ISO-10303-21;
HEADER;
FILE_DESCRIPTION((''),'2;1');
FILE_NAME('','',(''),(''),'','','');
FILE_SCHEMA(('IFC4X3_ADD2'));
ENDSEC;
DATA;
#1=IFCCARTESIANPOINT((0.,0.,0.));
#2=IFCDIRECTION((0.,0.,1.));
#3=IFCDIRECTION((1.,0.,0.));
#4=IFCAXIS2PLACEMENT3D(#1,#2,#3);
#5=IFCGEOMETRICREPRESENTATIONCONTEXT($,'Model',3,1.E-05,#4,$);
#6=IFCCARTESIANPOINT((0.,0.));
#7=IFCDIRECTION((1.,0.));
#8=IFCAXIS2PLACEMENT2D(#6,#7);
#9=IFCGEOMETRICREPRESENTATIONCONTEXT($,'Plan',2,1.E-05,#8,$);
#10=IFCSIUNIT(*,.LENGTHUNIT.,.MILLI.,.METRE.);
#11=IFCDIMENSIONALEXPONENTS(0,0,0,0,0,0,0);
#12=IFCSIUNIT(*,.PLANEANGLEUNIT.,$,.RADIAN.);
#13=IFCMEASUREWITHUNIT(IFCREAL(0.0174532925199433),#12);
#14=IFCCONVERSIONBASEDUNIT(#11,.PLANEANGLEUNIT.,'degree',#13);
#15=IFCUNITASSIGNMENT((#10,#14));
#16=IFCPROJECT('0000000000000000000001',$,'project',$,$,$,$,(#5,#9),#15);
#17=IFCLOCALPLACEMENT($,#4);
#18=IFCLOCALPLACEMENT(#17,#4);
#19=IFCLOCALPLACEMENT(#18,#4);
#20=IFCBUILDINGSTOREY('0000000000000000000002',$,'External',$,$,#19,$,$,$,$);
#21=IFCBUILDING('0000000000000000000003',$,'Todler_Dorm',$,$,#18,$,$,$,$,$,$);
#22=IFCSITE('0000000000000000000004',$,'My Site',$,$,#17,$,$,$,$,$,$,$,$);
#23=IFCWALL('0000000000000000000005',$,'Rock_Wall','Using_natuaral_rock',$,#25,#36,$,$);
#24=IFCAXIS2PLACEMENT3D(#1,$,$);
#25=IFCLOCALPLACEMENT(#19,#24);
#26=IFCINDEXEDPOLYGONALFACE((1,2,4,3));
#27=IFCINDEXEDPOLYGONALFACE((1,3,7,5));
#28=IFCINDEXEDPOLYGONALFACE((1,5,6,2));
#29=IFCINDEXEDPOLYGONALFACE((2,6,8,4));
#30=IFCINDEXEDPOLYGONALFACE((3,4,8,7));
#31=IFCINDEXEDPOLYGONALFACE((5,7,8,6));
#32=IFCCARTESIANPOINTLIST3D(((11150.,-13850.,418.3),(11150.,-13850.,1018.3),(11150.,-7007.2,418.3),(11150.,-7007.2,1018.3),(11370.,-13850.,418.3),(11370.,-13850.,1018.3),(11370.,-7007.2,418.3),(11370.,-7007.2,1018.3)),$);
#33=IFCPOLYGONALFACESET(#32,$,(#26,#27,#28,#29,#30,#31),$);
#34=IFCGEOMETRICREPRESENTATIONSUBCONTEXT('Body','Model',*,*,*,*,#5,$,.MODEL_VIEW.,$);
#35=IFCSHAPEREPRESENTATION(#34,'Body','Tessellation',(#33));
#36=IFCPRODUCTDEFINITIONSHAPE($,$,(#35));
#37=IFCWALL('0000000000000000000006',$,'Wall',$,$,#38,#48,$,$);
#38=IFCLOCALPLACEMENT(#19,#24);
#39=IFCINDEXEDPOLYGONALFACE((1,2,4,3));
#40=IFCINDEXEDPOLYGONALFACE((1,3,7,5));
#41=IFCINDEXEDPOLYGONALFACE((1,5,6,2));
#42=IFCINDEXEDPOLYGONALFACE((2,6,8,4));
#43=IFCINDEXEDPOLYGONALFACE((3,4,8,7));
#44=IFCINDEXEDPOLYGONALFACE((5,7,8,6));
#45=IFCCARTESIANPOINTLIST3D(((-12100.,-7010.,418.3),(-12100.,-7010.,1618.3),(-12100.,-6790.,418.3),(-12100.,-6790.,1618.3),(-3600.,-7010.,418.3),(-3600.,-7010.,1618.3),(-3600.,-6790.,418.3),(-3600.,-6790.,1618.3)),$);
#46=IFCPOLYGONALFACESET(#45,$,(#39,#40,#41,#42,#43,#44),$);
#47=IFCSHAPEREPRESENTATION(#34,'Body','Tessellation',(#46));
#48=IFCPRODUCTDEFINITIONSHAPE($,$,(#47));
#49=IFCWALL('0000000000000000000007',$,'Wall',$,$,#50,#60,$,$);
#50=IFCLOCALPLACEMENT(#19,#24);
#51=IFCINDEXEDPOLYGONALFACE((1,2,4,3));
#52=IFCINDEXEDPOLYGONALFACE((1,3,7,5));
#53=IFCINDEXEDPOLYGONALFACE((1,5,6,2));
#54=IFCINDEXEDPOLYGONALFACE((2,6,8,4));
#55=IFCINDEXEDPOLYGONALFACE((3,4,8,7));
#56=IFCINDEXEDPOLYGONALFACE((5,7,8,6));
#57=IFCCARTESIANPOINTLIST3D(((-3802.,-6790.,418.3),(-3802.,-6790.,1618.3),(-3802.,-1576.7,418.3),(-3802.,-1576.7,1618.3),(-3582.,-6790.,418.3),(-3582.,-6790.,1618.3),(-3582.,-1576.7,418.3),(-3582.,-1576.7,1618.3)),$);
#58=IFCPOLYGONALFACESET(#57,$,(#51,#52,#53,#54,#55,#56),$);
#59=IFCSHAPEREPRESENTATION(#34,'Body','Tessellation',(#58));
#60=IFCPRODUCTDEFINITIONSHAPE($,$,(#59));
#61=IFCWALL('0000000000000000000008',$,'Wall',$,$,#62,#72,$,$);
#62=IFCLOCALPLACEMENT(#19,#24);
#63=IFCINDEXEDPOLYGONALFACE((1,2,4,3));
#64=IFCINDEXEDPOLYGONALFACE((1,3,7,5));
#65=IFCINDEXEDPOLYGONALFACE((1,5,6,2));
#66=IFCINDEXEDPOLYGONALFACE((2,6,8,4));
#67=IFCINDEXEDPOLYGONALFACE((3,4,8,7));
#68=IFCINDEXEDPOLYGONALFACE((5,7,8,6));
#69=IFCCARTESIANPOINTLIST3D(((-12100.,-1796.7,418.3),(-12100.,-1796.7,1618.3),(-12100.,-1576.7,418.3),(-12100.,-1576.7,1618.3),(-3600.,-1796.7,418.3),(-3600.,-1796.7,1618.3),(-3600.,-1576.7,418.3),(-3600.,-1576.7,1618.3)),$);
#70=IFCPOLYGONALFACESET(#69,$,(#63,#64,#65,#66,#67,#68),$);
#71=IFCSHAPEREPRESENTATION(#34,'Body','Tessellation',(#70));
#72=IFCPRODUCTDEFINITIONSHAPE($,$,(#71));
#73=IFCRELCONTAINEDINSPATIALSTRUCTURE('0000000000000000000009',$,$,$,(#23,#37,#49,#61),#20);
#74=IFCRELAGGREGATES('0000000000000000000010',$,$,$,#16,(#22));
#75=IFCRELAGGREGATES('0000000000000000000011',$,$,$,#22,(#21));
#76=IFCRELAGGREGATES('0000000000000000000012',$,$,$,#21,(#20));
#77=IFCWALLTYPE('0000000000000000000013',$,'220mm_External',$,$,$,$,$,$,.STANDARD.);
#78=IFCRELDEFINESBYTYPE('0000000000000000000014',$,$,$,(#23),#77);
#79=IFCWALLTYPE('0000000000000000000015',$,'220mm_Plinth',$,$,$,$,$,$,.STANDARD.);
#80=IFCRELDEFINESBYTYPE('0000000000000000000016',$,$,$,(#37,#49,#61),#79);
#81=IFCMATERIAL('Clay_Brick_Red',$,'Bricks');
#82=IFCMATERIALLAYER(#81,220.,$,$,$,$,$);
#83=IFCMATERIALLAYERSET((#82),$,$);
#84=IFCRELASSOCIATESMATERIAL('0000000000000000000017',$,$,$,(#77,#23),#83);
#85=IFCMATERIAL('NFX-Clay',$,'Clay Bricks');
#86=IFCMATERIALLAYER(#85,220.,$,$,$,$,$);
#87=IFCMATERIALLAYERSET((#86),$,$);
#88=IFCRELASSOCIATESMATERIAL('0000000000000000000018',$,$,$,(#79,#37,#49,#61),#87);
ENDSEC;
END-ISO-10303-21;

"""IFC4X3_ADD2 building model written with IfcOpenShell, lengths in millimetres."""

from ifc_helpers import new_model, entity, si_unit, converted_unit, frame, origin_with_axes, origin_2d_with_axis, place, context, subcontext, project, spatial, line, indexed_curve, outline, extrude, material, layer, layer_set, layer_usage, type_object, element, save


model = new_model("IFC4X3_ADD2")

# Units and contexts
model_context = context("Model", 3, precision=1e-05, world=origin_with_axes())
plan_context = context("Plan", 2, precision=1e-05, world=origin_2d_with_axis())
body_context_1 = subcontext(model_context, "Body", "Model", "MODEL_VIEW")
ifc_project = project(units=[si_unit("LENGTHUNIT", "METRE", prefix="MILLI"), converted_unit("PLANEANGLEUNIT", "degree", entity("IfcReal", 0.0174532925199433), si_unit("PLANEANGLEUNIT", "RADIAN"), dimensions=[0, 0, 0, 0, 0, 0, 0])], contexts=[model_context, plan_context])

# Site, building, storey
site_placement = place(None, origin_with_axes())
site = spatial("IfcSite", under=ifc_project, at=site_placement, Name="My Site")
building_placement = place(site_placement, origin_with_axes())
building = spatial("IfcBuilding", under=site, at=building_placement, Name="Todler_Dorm")
storey_placement = place(building_placement, origin_with_axes())
storey = spatial("IfcBuildingStorey", under=building, at=storey_placement, Name="External")

# Shared definitions
ifc_material_1 = material(Name="Clay_Brick_Red", Category="Bricks")
ifc_layer_1 = layer(ifc_material_1, 220.0)
ifc_layer_set_1 = layer_set([ifc_layer_1])
wall_type_1 = type_object("IfcWallType", Name="220mm_External", PredefinedType="STANDARD", material=ifc_layer_set_1)

# Walls
ifc_layer_usage_1 = layer_usage(ifc_layer_set_1, "AXIS2", "POSITIVE", 0.0)
wall_1_placement = place(storey_placement, frame((11370.0, -13850.0, 418.3), z_axis=(0.0, 0.0, 1.0), x_axis=(0.0, 1.0, 0.0)))
element("IfcWall", 1, at=wall_1_placement, inside=storey, type_object=wall_type_1, material=ifc_layer_usage_1, Name="Rock_Wall", Description="Using_natuaral_rock", context=body_context_1, shape_type="SweptSolid", body=[
    extrude(outline(indexed_curve([(0.0, 0.0), (0.0, 220.0), (6842.8, 220.0), (6842.8, 0.0)], segments=[line(1, 2, 3, 4, 1)])), origin_with_axes(), (0.0, 0.0, 1.0), 600.0),
])
ifc_material_2 = material(Name="NFX-Clay", Category="Clay Bricks")
ifc_layer_2 = layer(ifc_material_2, 220.0)
ifc_layer_set_2 = layer_set([ifc_layer_2])
ifc_layer_usage_2 = layer_usage(ifc_layer_set_2, "AXIS2", "POSITIVE", 0.0)
wall_type_2 = type_object("IfcWallType", Name="220mm_Plinth", PredefinedType="STANDARD", material=ifc_layer_set_2)
wall_2_placement = place(storey_placement, frame((-3600.0, -6790.0, 418.3), z_axis=(0.0, 0.0, 1.0), x_axis=(-1.0, 0.0, 0.0)))
element("IfcWall", 2, at=wall_2_placement, inside=storey, type_object=wall_type_2, material=ifc_layer_usage_2, Name="Wall", context=body_context_1, shape_type="SweptSolid", body=[
    extrude(outline(indexed_curve([(0.0, 0.0), (0.0, 220.0), (8500.0, 220.0), (8500.0, 0.0)], segments=[line(1, 2, 3, 4, 1)])), origin_with_axes(), (0.0, 0.0, 1.0), 1200.0),
])
ifc_layer_usage_3 = layer_usage(ifc_layer_set_2, "AXIS2", "POSITIVE", 0.0)
wall_3_placement = place(storey_placement, frame((-3802.0, -1576.7, 418.3), z_axis=(0.0, 0.0, 1.0), x_axis=(0.000001, -1.0, 0.0)))
element("IfcWall", 3, at=wall_3_placement, inside=storey, type_object=wall_type_2, material=ifc_layer_usage_3, Name="Wall", context=body_context_1, shape_type="SweptSolid", body=[
    extrude(outline(indexed_curve([(0.0, 0.0), (0.0, 220.0), (5213.3, 220.0), (5213.3, 0.0)], segments=[line(1, 2, 3, 4, 1)])), origin_with_axes(), (0.0, 0.0, 1.0), 1200.0),
])
ifc_layer_usage_4 = layer_usage(ifc_layer_set_2, "AXIS2", "POSITIVE", 0.0)
wall_4_placement = place(storey_placement, frame((-3600.0, -1576.7, 418.3), z_axis=(0.0, 0.0, 1.0), x_axis=(-1.0, 0.0, 0.0)))
element("IfcWall", 4, at=wall_4_placement, inside=storey, type_object=wall_type_2, material=ifc_layer_usage_4, Name="Wall", context=body_context_1, shape_type="SweptSolid", body=[
    extrude(outline(indexed_curve([(0.0, 0.0), (0.0, 220.0), (8500.0, 220.0), (8500.0, 0.0)], segments=[line(1, 2, 3, 4, 1)])), origin_with_axes(), (0.0, 0.0, 1.0), 1200.0),
])

save(model, "model.ifc")
